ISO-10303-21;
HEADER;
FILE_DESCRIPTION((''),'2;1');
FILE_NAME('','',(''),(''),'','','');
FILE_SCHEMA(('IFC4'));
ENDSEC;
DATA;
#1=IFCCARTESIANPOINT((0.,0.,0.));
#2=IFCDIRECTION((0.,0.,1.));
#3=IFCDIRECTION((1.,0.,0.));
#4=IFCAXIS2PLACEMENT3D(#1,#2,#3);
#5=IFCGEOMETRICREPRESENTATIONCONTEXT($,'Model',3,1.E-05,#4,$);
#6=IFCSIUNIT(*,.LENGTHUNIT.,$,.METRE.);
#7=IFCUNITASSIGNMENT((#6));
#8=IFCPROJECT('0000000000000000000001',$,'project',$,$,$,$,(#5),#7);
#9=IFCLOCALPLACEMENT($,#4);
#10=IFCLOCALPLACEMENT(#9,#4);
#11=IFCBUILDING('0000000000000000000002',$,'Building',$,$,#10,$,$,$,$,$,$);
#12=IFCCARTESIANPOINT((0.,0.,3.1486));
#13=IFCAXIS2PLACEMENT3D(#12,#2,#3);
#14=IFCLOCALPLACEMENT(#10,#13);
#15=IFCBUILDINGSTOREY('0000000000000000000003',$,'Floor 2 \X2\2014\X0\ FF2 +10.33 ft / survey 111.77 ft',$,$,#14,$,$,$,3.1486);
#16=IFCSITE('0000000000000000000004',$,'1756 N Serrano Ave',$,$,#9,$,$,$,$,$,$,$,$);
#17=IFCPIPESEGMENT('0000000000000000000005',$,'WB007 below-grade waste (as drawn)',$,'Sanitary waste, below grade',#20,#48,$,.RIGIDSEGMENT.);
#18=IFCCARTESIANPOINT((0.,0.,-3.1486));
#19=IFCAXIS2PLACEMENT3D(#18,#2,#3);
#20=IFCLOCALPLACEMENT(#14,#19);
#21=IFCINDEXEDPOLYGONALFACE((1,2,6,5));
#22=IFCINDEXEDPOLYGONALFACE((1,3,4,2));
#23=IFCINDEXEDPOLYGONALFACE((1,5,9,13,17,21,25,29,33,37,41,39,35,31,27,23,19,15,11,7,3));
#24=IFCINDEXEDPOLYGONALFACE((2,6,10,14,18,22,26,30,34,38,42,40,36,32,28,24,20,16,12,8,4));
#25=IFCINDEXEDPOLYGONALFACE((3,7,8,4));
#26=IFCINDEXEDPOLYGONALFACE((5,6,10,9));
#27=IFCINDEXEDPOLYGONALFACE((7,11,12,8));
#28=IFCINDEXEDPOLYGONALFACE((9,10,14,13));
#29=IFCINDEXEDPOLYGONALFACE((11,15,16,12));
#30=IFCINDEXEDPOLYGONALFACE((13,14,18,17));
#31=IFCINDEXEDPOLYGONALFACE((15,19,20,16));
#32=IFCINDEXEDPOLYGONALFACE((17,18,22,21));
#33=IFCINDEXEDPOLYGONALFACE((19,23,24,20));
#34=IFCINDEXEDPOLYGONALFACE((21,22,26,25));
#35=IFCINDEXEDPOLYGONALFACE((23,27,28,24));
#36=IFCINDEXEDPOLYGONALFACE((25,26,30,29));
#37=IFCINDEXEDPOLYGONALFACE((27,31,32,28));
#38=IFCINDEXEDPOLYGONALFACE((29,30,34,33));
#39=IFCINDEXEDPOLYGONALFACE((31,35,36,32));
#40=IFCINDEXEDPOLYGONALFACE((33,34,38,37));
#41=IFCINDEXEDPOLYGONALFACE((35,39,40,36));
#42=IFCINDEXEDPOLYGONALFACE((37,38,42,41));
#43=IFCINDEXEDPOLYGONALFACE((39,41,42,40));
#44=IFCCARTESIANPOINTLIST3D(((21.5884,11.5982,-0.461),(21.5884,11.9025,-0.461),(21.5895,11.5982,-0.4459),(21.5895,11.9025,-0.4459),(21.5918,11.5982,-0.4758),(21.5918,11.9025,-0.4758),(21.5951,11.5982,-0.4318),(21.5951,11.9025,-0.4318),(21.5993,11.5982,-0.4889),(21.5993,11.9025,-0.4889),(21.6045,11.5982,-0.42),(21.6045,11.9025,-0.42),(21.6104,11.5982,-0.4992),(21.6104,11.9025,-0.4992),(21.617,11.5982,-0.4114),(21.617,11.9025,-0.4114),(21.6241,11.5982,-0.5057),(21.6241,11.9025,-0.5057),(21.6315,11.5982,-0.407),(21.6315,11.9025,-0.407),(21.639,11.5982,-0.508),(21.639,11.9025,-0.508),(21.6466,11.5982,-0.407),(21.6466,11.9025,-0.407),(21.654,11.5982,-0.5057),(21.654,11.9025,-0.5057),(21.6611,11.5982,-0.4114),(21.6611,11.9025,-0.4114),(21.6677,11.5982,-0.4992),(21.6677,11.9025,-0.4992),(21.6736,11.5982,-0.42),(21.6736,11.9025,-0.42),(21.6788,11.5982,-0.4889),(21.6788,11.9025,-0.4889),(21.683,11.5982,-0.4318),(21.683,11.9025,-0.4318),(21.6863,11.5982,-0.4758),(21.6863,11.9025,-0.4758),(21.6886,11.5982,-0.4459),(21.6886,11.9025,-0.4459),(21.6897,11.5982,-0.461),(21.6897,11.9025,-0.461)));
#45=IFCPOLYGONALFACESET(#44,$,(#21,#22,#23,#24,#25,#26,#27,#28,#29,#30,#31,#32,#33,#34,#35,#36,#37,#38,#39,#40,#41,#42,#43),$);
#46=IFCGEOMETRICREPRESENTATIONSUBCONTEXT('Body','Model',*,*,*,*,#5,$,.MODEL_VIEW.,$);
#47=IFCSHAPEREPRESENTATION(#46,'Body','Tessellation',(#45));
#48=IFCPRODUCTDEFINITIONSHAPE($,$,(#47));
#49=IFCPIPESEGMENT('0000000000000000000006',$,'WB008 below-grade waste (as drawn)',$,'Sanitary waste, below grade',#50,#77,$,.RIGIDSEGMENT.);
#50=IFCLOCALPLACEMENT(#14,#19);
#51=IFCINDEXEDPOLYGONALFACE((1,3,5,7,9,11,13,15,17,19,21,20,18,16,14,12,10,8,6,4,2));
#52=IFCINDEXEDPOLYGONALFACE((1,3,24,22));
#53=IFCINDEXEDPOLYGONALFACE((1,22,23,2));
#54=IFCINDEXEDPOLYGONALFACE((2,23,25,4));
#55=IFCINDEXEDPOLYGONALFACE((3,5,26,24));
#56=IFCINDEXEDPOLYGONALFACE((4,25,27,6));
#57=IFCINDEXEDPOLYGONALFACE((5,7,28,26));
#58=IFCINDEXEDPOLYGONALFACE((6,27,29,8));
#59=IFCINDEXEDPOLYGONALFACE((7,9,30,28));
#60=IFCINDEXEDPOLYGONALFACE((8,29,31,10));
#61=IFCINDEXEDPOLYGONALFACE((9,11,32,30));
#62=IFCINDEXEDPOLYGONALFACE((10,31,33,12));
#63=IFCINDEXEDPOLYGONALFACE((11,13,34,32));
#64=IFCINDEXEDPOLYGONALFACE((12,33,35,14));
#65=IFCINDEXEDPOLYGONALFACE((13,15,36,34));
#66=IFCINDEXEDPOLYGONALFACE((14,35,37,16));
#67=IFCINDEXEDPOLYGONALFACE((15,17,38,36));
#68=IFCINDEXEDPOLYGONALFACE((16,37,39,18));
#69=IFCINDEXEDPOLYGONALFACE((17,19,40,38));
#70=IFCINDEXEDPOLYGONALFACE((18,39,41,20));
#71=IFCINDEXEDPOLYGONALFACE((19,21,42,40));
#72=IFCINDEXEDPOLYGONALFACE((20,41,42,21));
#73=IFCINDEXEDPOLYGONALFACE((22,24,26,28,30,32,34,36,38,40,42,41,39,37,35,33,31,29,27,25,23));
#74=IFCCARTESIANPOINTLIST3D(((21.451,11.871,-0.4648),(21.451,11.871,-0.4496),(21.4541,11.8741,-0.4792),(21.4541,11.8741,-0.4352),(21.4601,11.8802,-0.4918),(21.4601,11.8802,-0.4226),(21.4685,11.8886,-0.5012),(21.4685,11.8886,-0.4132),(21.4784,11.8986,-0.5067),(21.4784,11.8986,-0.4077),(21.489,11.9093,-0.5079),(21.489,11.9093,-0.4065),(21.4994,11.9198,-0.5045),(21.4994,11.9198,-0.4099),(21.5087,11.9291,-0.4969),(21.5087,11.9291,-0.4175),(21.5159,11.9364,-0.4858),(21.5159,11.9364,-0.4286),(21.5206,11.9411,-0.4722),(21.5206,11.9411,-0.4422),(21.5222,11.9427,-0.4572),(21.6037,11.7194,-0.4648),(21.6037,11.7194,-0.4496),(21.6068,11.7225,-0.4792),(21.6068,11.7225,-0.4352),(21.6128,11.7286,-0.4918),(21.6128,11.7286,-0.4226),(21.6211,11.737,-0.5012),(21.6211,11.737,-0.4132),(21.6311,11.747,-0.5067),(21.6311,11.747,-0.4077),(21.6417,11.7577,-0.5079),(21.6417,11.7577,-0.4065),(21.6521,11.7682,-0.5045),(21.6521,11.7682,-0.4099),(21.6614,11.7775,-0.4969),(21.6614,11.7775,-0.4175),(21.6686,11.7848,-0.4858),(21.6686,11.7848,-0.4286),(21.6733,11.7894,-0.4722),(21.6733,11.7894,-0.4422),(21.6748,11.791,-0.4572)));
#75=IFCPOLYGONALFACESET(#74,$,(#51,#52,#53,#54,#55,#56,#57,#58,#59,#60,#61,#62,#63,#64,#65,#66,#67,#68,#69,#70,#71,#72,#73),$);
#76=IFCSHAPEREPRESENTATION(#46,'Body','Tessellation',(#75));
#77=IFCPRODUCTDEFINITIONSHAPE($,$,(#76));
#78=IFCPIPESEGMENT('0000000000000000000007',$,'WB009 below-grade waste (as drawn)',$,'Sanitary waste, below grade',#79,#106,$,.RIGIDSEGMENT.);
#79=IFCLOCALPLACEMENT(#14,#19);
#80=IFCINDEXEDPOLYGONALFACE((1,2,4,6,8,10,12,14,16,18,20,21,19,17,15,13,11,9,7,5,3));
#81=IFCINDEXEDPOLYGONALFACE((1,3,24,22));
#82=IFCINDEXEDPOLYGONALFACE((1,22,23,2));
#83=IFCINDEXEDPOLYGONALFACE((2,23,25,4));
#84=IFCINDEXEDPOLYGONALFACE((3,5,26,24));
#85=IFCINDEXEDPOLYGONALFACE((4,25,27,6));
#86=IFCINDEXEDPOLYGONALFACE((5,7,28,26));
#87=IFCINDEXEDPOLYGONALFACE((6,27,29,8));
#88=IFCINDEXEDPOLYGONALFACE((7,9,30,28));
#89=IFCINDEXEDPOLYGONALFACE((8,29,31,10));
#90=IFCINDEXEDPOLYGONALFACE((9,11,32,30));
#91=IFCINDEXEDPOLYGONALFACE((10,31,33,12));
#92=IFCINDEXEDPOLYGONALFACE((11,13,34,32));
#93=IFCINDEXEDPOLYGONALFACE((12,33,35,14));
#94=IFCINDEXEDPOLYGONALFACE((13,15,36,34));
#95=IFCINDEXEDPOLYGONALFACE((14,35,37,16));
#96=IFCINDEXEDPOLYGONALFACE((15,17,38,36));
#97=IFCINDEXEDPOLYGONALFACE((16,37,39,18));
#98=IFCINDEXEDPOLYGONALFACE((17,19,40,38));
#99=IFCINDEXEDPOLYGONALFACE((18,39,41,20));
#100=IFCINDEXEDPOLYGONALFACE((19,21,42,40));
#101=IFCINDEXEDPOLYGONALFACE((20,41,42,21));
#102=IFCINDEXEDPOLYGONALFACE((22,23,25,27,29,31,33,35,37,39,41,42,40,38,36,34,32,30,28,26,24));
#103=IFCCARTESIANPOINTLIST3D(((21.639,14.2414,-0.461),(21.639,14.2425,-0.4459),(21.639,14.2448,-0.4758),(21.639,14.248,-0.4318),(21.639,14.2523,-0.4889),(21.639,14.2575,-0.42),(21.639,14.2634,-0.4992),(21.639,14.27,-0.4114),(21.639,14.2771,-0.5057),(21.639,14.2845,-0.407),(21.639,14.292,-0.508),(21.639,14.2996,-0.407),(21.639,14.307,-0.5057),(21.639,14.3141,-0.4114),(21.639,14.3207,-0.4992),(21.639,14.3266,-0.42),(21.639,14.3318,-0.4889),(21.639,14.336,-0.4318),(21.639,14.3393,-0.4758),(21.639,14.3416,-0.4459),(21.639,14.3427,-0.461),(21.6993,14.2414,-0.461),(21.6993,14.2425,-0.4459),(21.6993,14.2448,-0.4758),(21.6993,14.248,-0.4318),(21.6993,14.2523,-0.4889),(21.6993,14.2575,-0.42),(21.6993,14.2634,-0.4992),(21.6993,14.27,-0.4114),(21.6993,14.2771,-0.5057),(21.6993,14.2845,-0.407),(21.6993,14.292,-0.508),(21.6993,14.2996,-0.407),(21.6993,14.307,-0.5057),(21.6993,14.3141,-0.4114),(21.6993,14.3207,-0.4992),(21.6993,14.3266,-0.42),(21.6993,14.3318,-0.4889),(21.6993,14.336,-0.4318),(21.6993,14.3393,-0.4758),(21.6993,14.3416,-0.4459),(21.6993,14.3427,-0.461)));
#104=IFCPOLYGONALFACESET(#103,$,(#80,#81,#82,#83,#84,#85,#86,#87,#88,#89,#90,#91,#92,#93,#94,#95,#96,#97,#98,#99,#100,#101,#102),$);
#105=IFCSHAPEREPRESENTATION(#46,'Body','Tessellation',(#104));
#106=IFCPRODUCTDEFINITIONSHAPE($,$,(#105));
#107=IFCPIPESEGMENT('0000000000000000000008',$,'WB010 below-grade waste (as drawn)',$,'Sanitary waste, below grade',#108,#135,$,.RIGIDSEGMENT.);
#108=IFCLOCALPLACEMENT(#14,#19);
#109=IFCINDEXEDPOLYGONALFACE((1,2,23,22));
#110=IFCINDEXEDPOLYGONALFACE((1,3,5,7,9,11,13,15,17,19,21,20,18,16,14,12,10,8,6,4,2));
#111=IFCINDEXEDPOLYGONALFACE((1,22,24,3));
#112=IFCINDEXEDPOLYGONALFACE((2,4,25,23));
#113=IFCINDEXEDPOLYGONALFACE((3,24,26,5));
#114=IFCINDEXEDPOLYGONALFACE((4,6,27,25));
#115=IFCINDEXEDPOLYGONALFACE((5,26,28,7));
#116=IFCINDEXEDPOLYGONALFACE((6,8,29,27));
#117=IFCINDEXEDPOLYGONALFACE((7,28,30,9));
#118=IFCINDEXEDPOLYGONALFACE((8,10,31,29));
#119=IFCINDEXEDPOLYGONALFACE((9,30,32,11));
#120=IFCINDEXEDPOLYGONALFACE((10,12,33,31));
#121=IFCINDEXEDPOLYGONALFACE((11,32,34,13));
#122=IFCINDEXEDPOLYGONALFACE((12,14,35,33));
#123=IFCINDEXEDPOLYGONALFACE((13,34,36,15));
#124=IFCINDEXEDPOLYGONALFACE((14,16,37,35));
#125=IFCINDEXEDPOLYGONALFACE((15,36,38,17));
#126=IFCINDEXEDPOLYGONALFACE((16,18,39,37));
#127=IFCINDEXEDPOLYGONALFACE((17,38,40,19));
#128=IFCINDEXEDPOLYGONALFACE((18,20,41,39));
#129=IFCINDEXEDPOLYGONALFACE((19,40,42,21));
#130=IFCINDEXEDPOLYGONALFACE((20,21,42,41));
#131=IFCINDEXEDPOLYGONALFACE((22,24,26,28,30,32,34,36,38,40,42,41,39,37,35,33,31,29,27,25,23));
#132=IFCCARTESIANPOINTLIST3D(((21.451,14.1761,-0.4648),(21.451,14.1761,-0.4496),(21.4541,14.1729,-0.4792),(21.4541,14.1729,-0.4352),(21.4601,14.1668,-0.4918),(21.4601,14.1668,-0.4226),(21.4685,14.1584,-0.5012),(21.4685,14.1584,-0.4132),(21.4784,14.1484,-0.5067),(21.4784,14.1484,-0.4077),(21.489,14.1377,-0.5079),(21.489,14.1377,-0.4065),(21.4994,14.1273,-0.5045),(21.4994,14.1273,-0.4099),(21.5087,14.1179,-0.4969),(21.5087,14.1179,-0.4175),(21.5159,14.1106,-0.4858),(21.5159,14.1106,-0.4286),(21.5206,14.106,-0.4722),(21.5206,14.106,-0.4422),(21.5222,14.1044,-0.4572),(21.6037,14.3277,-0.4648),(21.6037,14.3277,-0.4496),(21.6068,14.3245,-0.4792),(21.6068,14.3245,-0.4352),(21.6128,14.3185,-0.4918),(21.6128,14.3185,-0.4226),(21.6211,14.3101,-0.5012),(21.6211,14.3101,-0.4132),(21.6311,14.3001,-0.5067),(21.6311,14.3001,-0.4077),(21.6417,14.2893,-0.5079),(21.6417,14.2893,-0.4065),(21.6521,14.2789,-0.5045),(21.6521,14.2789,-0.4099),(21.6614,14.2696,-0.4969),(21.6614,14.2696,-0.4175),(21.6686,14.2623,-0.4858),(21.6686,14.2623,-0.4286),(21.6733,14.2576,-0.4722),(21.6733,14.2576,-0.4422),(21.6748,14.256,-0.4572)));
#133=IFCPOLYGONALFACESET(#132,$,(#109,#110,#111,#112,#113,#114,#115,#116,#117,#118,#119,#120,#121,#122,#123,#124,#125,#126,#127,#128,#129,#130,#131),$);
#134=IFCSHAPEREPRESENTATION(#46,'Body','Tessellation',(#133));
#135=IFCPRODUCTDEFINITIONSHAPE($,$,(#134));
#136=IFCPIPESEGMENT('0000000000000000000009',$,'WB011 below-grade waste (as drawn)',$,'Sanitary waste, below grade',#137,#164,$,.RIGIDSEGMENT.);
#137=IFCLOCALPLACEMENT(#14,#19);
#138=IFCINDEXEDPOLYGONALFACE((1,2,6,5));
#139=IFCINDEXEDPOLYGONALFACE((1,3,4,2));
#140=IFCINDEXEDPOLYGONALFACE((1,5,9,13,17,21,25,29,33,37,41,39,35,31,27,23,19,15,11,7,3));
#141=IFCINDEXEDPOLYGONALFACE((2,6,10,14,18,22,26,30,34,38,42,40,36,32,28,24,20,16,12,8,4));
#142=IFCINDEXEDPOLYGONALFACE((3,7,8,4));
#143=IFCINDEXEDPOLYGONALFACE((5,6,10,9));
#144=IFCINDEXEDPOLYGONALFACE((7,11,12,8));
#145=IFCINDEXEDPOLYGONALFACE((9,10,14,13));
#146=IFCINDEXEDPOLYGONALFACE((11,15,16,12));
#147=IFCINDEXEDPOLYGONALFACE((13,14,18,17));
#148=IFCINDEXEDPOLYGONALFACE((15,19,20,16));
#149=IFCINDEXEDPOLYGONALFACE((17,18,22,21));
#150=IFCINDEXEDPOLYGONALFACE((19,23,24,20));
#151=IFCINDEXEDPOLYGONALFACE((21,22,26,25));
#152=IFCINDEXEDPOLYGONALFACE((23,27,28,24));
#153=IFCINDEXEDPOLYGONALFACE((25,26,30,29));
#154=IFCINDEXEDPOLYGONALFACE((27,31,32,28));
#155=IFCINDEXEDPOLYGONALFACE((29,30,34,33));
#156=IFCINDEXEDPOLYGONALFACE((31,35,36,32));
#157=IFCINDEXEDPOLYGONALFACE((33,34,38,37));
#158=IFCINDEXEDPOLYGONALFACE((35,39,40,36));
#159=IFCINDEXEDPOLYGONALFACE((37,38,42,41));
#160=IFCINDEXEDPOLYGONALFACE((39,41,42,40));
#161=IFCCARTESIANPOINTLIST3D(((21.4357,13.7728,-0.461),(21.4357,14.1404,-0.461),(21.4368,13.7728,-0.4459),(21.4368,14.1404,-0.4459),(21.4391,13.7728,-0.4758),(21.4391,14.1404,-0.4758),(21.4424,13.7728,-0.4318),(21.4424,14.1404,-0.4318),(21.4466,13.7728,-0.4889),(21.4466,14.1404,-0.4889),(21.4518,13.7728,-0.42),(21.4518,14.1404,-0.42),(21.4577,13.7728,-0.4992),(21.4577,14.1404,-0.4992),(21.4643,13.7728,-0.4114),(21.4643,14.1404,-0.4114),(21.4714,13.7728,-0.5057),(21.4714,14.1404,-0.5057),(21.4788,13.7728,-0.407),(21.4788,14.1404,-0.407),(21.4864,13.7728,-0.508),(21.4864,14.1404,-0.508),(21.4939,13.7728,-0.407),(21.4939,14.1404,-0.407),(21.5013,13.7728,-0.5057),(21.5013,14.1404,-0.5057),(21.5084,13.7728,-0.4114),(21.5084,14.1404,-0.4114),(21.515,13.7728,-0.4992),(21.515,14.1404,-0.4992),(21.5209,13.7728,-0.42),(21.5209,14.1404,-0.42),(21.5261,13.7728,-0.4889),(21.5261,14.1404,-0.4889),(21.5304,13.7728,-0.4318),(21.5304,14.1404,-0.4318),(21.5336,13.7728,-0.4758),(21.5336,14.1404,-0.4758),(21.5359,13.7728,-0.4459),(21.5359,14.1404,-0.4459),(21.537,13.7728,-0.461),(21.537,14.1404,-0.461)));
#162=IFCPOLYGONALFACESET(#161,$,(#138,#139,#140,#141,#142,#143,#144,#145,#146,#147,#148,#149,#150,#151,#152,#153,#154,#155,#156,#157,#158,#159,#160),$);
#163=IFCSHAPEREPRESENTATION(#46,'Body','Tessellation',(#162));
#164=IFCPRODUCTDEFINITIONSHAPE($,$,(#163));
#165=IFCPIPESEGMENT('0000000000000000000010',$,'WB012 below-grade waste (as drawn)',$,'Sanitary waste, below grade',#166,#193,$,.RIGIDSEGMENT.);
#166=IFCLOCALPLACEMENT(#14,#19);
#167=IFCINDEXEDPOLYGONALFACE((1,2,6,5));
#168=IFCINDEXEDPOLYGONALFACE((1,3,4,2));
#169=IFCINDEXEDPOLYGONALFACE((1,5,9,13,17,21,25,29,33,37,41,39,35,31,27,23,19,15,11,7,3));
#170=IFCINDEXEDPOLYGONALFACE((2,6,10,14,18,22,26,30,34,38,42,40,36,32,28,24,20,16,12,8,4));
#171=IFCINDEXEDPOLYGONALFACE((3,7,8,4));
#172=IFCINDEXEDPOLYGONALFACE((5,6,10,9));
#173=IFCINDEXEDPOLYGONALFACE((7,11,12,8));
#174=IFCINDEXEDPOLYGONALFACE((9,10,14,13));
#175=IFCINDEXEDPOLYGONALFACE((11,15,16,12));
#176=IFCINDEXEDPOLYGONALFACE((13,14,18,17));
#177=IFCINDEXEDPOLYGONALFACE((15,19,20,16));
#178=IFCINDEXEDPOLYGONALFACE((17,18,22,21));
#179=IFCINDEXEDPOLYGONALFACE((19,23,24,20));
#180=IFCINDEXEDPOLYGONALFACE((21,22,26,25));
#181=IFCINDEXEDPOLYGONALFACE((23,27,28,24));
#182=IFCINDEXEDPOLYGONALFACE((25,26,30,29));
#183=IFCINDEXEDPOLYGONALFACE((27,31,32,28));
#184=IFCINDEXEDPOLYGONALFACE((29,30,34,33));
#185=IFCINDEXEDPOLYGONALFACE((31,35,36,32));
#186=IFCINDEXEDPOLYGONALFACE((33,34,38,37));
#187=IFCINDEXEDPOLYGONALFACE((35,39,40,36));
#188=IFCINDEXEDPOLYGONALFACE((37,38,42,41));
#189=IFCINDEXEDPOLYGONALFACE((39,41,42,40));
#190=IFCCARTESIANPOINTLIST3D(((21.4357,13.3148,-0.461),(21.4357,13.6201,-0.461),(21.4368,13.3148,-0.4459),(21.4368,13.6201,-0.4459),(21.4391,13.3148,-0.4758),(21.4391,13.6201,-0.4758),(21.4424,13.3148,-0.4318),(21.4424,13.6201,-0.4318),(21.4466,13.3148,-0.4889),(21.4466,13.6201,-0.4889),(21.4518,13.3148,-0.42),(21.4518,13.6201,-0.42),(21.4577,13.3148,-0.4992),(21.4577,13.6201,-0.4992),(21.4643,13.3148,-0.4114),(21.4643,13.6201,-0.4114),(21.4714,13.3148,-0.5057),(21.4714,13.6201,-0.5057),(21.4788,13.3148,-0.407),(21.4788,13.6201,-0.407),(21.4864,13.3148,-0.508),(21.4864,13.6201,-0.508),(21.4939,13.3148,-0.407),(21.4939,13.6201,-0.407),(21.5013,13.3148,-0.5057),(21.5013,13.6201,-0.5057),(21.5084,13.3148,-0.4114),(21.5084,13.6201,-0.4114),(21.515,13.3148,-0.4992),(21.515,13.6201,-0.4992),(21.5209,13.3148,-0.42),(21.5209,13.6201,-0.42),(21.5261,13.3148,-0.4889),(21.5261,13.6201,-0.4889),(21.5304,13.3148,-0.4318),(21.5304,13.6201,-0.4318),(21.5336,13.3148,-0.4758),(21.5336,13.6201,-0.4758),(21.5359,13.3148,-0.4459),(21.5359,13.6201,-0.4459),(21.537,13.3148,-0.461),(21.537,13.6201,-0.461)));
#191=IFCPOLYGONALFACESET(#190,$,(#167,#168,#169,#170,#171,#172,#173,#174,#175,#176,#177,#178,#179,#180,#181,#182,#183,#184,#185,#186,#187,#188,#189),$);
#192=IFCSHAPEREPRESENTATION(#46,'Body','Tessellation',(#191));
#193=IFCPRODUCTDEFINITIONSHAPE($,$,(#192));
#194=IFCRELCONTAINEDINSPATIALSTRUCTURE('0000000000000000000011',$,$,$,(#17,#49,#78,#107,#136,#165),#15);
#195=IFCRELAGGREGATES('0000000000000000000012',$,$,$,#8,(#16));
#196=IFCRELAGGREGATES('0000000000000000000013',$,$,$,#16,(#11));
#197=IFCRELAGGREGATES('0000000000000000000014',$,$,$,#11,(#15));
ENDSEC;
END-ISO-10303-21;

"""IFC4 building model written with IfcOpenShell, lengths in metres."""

from ifc_helpers import new_model, entity, si_unit, frame, origin_with_axes, place, context, subcontext, project, spatial, element, save


model = new_model("IFC4")

# Units and contexts
model_context = context("Model", 3, precision=1e-05, world=origin_with_axes())
body_context = subcontext(model_context, "Body", "Model", "MODEL_VIEW")
ifc_project = project(units=[si_unit("LENGTHUNIT", "METRE")], contexts=[model_context])

# Site, building, storey
site_placement = place(None, origin_with_axes())
site = spatial("IfcSite", under=ifc_project, at=site_placement, Name="1756 N Serrano Ave")
building_placement = place(site_placement, origin_with_axes())
building = spatial("IfcBuilding", under=site, at=building_placement, Name="Building")
storey_placement = place(building_placement, frame((0.0, 0.0, 3.1486), z_axis=(0.0, 0.0, 1.0), x_axis=(1.0, 0.0, 0.0)))
storey = spatial("IfcBuildingStorey", under=building, at=storey_placement, Name="Floor 2 — FF2 +10.33 ft / survey 111.77 ft", Elevation=3.1486)

# Pipe segments
pipe_segment_1_placement = place(storey_placement, frame((0.0, 0.0, -3.1486), z_axis=(0.0, 0.0, 1.0), x_axis=(1.0, 0.0, 0.0)))
element("IfcPipeSegment", 1, at=pipe_segment_1_placement, inside=storey, Name="WB007 below-grade waste (as drawn)", ObjectType="Sanitary waste, below grade", PredefinedType="RIGIDSEGMENT", context=body_context, shape_type="AdvancedSweptSolid", body=[
    entity("IfcSweptDiskSolid", entity("IfcPolyline", [entity("IfcCartesianPoint", [21.639, 11.9025, -0.4572]), entity("IfcCartesianPoint", [21.639, 11.5982, -0.4572])]), 0.0508),
])
pipe_segment_2_placement = place(storey_placement, frame((0.0, 0.0, -3.1486), z_axis=(0.0, 0.0, 1.0), x_axis=(1.0, 0.0, 0.0)))
element("IfcPipeSegment", 2, at=pipe_segment_2_placement, inside=storey, Name="WB008 below-grade waste (as drawn)", ObjectType="Sanitary waste, below grade", PredefinedType="RIGIDSEGMENT", context=body_context, shape_type="AdvancedSweptSolid", body=[
    entity("IfcSweptDiskSolid", entity("IfcPolyline", [entity("IfcCartesianPoint", [21.4864, 11.9066, -0.4572]), entity("IfcCartesianPoint", [21.639, 11.755, -0.4572])]), 0.0508),
])
pipe_segment_3_placement = place(storey_placement, frame((0.0, 0.0, -3.1486), z_axis=(0.0, 0.0, 1.0), x_axis=(1.0, 0.0, 0.0)))
element("IfcPipeSegment", 3, at=pipe_segment_3_placement, inside=storey, Name="WB009 below-grade waste (as drawn)", ObjectType="Sanitary waste, below grade", PredefinedType="RIGIDSEGMENT", context=body_context, shape_type="AdvancedSweptSolid", body=[
    entity("IfcSweptDiskSolid", entity("IfcPolyline", [entity("IfcCartesianPoint", [21.6993, 14.292, -0.4572]), entity("IfcCartesianPoint", [21.639, 14.292, -0.4572])]), 0.0508),
])
pipe_segment_4_placement = place(storey_placement, frame((0.0, 0.0, -3.1486), z_axis=(0.0, 0.0, 1.0), x_axis=(1.0, 0.0, 0.0)))
element("IfcPipeSegment", 4, at=pipe_segment_4_placement, inside=storey, Name="WB010 below-grade waste (as drawn)", ObjectType="Sanitary waste, below grade", PredefinedType="RIGIDSEGMENT", context=body_context, shape_type="AdvancedSweptSolid", body=[
    entity("IfcSweptDiskSolid", entity("IfcPolyline", [entity("IfcCartesianPoint", [21.639, 14.292, -0.4572]), entity("IfcCartesianPoint", [21.4864, 14.1404, -0.4572])]), 0.0508),
])
pipe_segment_5_placement = place(storey_placement, frame((0.0, 0.0, -3.1486), z_axis=(0.0, 0.0, 1.0), x_axis=(1.0, 0.0, 0.0)))
element("IfcPipeSegment", 5, at=pipe_segment_5_placement, inside=storey, Name="WB011 below-grade waste (as drawn)", ObjectType="Sanitary waste, below grade", PredefinedType="RIGIDSEGMENT", context=body_context, shape_type="AdvancedSweptSolid", body=[
    entity("IfcSweptDiskSolid", entity("IfcPolyline", [entity("IfcCartesianPoint", [21.4864, 14.1404, -0.4572]), entity("IfcCartesianPoint", [21.4864, 13.7728, -0.4572])]), 0.0508),
])
pipe_segment_6_placement = place(storey_placement, frame((0.0, 0.0, -3.1486), z_axis=(0.0, 0.0, 1.0), x_axis=(1.0, 0.0, 0.0)))
element("IfcPipeSegment", 6, at=pipe_segment_6_placement, inside=storey, Name="WB012 below-grade waste (as drawn)", ObjectType="Sanitary waste, below grade", PredefinedType="RIGIDSEGMENT", context=body_context, shape_type="AdvancedSweptSolid", body=[
    entity("IfcSweptDiskSolid", entity("IfcPolyline", [entity("IfcCartesianPoint", [21.4864, 13.6201, -0.4572]), entity("IfcCartesianPoint", [21.4864, 13.3148, -0.4572])]), 0.0508),
])

save(model, "model.ifc")
